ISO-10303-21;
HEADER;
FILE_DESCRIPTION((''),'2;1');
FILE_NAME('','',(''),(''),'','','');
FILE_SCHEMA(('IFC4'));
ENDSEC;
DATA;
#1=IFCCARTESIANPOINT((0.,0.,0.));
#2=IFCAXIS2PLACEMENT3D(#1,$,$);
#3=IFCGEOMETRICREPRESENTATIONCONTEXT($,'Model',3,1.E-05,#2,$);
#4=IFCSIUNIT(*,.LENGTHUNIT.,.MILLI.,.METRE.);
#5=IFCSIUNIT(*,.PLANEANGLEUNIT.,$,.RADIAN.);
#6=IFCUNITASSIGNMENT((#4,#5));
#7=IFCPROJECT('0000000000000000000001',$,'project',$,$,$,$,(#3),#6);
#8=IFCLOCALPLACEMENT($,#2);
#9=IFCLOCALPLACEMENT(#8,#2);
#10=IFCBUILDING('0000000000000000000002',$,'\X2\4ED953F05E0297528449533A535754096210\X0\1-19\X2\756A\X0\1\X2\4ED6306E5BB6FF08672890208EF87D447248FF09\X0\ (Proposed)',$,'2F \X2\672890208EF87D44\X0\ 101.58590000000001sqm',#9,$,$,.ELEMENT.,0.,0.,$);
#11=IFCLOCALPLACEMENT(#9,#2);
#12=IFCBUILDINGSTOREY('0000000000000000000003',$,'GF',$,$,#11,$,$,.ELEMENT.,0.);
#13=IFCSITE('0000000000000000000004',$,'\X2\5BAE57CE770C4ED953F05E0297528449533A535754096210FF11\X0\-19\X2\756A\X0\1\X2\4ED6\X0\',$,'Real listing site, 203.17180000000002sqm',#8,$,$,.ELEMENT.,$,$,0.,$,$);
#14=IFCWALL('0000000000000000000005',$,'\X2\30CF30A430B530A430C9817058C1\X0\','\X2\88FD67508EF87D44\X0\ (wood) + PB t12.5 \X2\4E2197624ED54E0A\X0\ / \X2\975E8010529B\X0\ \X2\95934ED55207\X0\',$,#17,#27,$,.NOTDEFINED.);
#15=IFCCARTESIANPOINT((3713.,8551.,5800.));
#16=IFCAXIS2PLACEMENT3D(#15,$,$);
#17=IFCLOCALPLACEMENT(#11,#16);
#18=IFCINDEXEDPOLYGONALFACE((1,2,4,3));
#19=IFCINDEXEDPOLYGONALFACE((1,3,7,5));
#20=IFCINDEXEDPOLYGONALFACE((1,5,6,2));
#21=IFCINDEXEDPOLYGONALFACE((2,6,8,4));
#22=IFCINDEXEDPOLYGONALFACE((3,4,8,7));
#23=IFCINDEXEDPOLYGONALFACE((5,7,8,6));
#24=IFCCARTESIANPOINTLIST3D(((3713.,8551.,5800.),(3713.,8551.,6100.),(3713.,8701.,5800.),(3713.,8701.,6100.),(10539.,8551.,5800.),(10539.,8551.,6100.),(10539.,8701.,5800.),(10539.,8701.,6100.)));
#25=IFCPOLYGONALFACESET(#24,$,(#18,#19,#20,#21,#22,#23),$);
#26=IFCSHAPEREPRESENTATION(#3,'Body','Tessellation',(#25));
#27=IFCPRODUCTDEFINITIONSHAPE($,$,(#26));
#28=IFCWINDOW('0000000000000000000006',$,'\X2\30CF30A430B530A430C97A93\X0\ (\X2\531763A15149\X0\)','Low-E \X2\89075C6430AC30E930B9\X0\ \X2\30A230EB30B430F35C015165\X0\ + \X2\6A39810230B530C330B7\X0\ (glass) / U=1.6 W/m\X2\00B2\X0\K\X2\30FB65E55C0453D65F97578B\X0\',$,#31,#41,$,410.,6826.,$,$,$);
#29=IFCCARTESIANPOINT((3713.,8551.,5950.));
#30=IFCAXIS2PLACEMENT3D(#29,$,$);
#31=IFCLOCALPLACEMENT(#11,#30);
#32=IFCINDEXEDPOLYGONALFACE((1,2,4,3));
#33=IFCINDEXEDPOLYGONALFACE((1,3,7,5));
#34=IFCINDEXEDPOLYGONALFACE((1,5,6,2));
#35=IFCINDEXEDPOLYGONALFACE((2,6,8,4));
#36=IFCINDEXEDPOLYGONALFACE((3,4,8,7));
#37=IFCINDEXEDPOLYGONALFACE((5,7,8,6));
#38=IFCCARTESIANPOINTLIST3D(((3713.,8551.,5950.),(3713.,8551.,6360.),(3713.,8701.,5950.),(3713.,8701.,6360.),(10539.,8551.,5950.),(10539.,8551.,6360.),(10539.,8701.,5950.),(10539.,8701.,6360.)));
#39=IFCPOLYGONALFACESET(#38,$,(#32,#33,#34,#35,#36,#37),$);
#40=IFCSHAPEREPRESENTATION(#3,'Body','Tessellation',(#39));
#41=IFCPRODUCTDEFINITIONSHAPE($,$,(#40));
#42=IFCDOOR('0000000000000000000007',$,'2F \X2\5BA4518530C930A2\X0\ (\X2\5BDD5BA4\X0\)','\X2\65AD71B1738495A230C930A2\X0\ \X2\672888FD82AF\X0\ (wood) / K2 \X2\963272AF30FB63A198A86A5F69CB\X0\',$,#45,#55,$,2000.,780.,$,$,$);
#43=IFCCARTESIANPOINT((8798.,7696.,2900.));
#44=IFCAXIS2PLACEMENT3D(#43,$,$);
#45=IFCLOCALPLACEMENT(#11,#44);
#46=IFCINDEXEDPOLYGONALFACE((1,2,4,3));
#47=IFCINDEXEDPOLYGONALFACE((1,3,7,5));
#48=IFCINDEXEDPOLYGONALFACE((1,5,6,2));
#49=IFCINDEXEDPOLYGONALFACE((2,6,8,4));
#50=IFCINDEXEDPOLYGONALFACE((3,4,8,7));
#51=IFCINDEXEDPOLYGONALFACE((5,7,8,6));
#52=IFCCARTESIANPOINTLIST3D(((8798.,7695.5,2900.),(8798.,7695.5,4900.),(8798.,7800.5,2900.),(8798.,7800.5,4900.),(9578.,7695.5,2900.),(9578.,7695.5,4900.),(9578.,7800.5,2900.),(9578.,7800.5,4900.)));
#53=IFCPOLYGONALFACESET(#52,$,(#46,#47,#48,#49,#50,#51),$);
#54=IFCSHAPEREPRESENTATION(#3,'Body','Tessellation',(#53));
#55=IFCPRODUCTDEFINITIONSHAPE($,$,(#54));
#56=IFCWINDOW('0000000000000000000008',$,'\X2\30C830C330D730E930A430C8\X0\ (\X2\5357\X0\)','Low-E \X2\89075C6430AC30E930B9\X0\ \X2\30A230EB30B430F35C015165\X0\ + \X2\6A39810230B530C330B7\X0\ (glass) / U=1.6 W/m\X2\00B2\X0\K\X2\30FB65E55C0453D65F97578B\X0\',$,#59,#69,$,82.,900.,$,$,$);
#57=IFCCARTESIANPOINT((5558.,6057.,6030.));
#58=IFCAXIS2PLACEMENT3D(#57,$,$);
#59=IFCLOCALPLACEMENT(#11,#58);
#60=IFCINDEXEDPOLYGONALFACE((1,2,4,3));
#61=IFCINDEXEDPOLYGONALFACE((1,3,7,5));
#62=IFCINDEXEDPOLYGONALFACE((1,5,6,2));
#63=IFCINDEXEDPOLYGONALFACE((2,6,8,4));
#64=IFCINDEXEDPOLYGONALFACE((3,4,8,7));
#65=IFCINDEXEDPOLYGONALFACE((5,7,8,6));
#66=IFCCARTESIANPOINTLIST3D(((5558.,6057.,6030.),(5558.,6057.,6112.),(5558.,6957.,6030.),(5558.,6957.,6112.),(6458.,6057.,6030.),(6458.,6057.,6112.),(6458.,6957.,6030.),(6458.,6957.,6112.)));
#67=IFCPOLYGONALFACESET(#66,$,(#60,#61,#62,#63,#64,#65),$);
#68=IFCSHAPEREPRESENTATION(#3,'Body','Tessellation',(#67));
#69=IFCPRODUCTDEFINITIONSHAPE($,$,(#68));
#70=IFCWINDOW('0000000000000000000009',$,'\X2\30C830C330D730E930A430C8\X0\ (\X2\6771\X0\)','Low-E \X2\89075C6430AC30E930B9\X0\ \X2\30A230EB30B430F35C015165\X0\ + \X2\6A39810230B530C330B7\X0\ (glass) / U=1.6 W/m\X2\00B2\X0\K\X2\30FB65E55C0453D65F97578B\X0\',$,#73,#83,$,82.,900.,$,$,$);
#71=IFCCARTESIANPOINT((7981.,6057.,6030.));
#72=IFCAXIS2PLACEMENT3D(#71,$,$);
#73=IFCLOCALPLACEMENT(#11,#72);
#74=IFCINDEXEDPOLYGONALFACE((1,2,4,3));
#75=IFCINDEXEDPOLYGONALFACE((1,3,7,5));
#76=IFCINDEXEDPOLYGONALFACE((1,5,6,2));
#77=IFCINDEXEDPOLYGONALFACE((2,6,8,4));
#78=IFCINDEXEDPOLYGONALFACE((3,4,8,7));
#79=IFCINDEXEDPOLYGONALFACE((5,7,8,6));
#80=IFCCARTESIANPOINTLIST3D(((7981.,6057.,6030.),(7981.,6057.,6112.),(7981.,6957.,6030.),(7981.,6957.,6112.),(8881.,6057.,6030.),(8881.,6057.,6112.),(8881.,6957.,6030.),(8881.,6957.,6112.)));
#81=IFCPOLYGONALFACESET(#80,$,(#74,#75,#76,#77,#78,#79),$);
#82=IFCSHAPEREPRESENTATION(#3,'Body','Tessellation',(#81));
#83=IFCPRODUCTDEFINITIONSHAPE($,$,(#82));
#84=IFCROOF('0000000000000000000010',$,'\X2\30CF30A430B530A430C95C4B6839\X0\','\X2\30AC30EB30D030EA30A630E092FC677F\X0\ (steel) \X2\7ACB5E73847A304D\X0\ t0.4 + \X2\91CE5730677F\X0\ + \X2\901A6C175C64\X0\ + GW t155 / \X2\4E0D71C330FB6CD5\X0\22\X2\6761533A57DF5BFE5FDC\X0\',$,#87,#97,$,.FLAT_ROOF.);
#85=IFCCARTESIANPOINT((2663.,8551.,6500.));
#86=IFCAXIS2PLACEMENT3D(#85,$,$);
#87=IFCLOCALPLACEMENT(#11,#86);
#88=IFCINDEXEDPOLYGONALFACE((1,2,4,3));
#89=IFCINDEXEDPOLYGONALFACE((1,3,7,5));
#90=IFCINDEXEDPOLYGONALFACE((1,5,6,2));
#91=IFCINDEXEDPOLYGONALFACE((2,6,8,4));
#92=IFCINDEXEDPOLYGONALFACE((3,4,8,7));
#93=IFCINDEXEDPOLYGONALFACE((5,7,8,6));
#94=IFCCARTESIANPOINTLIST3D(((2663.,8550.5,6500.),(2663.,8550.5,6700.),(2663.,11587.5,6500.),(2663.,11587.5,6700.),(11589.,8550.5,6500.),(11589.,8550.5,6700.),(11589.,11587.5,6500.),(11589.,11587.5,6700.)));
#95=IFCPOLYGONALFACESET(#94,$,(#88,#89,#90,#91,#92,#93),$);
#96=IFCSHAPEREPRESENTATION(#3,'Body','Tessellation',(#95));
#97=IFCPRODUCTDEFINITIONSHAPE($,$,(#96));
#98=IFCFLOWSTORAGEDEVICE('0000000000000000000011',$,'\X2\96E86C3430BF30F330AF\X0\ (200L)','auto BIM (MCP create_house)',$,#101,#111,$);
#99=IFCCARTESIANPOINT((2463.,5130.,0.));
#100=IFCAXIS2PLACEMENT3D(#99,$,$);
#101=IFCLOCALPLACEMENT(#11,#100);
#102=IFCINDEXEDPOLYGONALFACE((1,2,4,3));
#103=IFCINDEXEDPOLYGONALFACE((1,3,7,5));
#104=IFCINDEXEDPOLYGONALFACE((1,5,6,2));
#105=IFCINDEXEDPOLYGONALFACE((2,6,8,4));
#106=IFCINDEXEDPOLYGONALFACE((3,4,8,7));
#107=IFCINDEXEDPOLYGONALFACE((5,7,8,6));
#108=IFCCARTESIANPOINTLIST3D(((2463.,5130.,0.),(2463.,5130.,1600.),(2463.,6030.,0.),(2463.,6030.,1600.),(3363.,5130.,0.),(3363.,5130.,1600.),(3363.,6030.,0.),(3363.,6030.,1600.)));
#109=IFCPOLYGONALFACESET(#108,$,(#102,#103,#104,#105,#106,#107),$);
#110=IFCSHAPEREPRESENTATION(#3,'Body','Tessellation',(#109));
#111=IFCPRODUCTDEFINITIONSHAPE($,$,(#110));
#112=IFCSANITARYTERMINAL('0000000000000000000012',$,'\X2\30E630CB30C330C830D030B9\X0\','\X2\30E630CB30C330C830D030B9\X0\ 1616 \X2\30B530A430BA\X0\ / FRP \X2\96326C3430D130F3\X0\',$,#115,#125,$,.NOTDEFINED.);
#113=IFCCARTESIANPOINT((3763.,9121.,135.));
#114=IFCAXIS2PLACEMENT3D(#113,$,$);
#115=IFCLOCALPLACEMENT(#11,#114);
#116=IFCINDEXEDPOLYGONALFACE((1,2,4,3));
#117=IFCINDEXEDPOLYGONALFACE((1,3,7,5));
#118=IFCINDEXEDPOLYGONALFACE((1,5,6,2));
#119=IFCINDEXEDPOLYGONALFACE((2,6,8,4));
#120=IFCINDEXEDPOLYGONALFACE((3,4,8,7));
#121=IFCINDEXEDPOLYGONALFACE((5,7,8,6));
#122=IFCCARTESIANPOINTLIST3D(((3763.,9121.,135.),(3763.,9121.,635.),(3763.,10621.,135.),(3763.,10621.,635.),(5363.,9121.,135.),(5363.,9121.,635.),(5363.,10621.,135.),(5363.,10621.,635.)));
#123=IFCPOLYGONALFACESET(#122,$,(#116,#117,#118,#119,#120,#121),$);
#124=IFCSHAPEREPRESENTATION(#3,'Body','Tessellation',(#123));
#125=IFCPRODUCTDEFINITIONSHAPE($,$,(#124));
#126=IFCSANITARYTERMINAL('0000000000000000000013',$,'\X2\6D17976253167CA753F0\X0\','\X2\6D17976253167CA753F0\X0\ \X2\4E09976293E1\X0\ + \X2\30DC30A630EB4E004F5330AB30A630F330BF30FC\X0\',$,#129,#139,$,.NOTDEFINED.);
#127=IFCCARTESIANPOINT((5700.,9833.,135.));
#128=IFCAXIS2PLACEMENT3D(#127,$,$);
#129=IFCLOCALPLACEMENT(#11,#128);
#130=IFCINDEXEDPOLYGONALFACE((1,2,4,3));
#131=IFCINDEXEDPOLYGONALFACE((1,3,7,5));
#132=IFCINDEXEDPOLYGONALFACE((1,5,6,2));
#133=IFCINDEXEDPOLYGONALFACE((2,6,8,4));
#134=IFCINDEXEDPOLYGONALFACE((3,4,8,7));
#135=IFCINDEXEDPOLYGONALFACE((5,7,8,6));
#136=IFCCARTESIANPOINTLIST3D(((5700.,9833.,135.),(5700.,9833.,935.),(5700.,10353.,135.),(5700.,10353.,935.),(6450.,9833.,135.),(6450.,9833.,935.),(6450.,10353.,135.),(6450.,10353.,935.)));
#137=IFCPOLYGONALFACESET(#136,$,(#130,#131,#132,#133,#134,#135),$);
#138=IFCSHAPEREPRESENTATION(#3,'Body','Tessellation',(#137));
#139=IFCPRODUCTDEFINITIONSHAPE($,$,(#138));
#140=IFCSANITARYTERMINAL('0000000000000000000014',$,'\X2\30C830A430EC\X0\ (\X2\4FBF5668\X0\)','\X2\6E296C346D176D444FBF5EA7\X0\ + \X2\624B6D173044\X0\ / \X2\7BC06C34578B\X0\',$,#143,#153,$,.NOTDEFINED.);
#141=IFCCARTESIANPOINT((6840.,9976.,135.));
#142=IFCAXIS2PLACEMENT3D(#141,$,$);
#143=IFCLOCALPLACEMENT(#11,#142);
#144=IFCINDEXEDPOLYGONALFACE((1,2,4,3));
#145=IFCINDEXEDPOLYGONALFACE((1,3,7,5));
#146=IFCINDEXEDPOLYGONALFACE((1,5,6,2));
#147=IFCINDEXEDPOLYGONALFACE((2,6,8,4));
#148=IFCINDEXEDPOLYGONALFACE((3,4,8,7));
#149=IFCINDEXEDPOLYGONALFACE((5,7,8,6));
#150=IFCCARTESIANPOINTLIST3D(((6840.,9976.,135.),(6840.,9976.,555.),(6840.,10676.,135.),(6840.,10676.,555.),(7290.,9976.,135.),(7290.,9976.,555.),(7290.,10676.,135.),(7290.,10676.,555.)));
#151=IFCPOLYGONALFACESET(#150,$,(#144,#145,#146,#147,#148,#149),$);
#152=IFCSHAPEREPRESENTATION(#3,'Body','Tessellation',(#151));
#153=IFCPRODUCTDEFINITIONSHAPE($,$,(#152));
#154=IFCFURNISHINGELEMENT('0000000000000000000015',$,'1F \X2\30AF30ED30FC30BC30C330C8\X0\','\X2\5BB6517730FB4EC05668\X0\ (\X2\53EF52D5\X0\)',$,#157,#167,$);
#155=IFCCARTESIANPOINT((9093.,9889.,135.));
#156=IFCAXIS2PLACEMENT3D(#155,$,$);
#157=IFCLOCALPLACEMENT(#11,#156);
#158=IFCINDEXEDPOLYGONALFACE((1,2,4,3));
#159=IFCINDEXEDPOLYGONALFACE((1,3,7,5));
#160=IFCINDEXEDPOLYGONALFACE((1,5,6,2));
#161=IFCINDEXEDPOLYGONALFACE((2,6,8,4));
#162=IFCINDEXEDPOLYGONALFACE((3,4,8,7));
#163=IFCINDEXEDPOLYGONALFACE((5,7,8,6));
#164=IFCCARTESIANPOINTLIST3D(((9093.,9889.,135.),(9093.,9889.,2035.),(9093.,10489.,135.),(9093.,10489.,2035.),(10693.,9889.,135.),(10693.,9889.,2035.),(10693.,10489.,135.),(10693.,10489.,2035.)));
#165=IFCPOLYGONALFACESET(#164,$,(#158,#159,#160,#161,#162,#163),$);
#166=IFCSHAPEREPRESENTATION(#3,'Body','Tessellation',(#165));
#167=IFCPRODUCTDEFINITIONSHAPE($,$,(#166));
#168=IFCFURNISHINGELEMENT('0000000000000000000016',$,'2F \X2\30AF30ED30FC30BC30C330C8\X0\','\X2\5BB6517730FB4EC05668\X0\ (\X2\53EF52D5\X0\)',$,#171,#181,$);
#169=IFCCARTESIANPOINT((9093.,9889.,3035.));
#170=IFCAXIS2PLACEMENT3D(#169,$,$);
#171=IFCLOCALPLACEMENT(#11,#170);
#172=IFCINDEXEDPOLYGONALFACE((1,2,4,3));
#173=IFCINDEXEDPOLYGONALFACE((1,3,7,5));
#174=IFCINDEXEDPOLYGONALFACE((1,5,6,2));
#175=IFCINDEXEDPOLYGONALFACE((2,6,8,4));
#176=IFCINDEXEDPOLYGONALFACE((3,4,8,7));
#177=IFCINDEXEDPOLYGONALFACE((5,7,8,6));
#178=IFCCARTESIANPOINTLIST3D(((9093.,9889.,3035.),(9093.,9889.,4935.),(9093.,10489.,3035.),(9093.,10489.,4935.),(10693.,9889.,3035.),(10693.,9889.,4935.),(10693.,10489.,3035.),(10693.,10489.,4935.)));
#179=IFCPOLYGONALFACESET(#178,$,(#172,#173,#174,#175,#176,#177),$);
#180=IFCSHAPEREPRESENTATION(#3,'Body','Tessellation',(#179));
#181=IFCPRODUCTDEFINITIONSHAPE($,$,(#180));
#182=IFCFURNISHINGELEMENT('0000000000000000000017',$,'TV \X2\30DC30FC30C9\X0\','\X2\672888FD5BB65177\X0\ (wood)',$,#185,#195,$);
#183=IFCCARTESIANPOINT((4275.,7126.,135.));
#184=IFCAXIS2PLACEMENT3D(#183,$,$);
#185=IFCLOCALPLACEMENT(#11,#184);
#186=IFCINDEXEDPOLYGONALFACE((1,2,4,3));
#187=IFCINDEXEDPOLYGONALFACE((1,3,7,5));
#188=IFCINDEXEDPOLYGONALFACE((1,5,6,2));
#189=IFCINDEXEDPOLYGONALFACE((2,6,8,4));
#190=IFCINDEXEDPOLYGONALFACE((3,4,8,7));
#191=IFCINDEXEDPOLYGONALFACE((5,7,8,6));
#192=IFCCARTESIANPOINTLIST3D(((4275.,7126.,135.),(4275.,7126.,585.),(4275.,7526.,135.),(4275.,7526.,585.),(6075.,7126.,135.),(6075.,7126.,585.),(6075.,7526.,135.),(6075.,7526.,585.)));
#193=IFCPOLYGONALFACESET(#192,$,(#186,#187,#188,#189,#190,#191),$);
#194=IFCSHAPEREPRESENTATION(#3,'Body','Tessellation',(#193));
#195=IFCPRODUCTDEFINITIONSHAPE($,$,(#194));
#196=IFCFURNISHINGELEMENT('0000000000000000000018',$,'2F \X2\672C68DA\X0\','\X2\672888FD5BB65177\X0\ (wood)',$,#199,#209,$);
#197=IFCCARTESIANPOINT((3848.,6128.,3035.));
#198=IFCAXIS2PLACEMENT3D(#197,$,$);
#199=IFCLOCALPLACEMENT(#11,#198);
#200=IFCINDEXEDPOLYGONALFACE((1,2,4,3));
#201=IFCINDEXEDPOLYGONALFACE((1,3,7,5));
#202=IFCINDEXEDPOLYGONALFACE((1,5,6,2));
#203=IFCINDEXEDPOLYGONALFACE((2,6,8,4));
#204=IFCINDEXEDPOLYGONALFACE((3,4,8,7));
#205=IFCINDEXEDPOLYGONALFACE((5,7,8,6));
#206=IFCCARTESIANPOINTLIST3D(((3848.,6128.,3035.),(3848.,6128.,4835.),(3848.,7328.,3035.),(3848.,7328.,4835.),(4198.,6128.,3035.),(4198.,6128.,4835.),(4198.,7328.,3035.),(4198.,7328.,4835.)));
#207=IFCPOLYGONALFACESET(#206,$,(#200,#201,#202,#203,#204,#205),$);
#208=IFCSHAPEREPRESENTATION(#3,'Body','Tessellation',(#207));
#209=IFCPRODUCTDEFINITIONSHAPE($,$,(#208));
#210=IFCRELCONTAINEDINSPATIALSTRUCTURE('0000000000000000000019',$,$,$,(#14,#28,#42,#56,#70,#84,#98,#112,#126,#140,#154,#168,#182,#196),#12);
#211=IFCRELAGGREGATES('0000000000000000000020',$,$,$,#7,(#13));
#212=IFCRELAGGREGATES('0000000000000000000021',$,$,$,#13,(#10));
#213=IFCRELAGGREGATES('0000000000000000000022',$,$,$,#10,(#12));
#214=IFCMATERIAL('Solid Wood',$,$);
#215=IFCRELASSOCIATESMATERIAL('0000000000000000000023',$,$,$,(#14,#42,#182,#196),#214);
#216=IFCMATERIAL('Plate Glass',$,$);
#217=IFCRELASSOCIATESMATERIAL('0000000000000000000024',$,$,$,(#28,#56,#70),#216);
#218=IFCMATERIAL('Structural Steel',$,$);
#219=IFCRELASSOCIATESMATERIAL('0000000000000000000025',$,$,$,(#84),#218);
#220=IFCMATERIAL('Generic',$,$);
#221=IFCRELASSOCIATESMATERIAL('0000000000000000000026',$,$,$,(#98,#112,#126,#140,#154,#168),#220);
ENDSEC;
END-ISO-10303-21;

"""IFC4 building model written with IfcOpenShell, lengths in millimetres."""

from ifc_helpers import new_model, si_unit, frame, frame_2d, origin, place, context, project, spatial, rectangle, extrude, material, element, fill, save


model = new_model("IFC4")

# Units and contexts
model_context = context("Model", 3, precision=1e-05, world=origin())
ifc_project = project(units=[si_unit("LENGTHUNIT", "METRE", prefix="MILLI"), si_unit("PLANEANGLEUNIT", "RADIAN")], contexts=[model_context])

# Site, building, storey
site_placement = place(None, origin())
site = spatial("IfcSite", under=ifc_project, at=site_placement, Name="宮城県仙台市青葉区南吉成１-19番1他", ObjectType="Real listing site, 203.17180000000002sqm", CompositionType="ELEMENT", RefElevation=0.0)
building_placement = place(site_placement, origin())
building = spatial("IfcBuilding", under=site, at=building_placement, Name="仙台市青葉区南吉成1-19番1他の家（木造軸組版） (Proposed)", ObjectType="2F 木造軸組 101.58590000000001sqm", CompositionType="ELEMENT", ElevationOfRefHeight=0.0, ElevationOfTerrain=0.0)
storey_placement = place(building_placement, origin())
storey = spatial("IfcBuildingStorey", under=building, at=storey_placement, Name="GF", CompositionType="ELEMENT", Elevation=0.0)

# Shared definitions
ifc_material_1 = material(Name="Solid Wood")
ifc_material_2 = material(Name="Plate Glass")

# Wall, opening, window
wall_1_placement = place(storey_placement, frame((3713.0, 8551.0, 5800.0)))
wall_1 = element("IfcWall", 1, at=wall_1_placement, inside=storey, material=ifc_material_1, Name="ハイサイド腰壁", Description="製材軸組 (wood) + PB t12.5 両面仕上 / 非耐力 間仕切", PredefinedType="NOTDEFINED", context=model_context, shape_type="SweptSolid", body=[
    extrude(rectangle(XDim=6826.0, YDim=150.0, at=frame_2d((3413.0, 75.0))), frame((3713.0, 8551.0, 5800.0)), (0.0, 0.0, 1.0), 700.0),
])
opening_1_placement = place(storey_placement, frame((3713.0, 8551.0, 5950.0)))
opening_1 = element("IfcOpeningElement", 2, at=opening_1_placement, cuts=wall_1, PredefinedType="NOTDEFINED", context=model_context, shape_type="SweptSolid", body=[
    extrude(rectangle(XDim=6826.0, YDim=150.0, at=frame_2d((3413.0, 75.0))), frame((3713.0, 8551.0, 5950.0)), (0.0, 0.0, 1.0), 410.0),
])
window_1_placement = place(storey_placement, frame((3713.0, 8551.0, 5950.0)))
window_1 = element("IfcWindow", 3, at=window_1_placement, inside=storey, material=ifc_material_2, Name="ハイサイド窓 (北採光)", Description="Low-E 複層ガラス アルゴン封入 + 樹脂サッシ (glass) / U=1.6 W/m²K・日射取得型", OverallHeight=410.0, OverallWidth=6826.0, context=model_context, shape_type="SweptSolid", body=[
    extrude(rectangle(XDim=6826.0, YDim=150.0, at=frame_2d((3413.0, 75.0))), frame((3713.0, 8551.0, 5950.0)), (0.0, 0.0, 1.0), 410.0),
])
fill(opening_1, window_1)

# Door
door_1_placement = place(storey_placement, frame((8798.0, 7696.0, 2900.0)))
element("IfcDoor", 4, at=door_1_placement, inside=storey, material=ifc_material_1, Name="2F 室内ドア (寝室)", Description="断熱玄関ドア 木製芯 (wood) / K2 防犯・採風機構", OverallHeight=2000.0, OverallWidth=780.0, context=model_context, shape_type="SweptSolid", body=[
    extrude(rectangle(XDim=780.0, YDim=105.0, at=frame_2d((390.0, 52.0))), frame((8798.0, 7696.0, 2900.0)), (0.0, 0.0, 1.0), 2000.0),
])

# Windows
window_2_placement = place(storey_placement, frame((5558.0, 6057.0, 6030.0)))
element("IfcWindow", 5, at=window_2_placement, inside=storey, material=ifc_material_2, Name="トップライト (南)", Description="Low-E 複層ガラス アルゴン封入 + 樹脂サッシ (glass) / U=1.6 W/m²K・日射取得型", OverallHeight=82.0, OverallWidth=900.0, context=model_context, shape_type="SweptSolid", body=[
    extrude(rectangle(XDim=900.0, YDim=900.0, at=frame_2d((450.0, 450.0))), frame((5558.0, 6057.0, 6030.0)), (0.0, 0.0, 1.0), 82.0),
])
window_3_placement = place(storey_placement, frame((7981.0, 6057.0, 6030.0)))
element("IfcWindow", 6, at=window_3_placement, inside=storey, material=ifc_material_2, Name="トップライト (東)", Description="Low-E 複層ガラス アルゴン封入 + 樹脂サッシ (glass) / U=1.6 W/m²K・日射取得型", OverallHeight=82.0, OverallWidth=900.0, context=model_context, shape_type="SweptSolid", body=[
    extrude(rectangle(XDim=900.0, YDim=900.0, at=frame_2d((450.0, 450.0))), frame((7981.0, 6057.0, 6030.0)), (0.0, 0.0, 1.0), 82.0),
])

# Roof
ifc_material_3 = material(Name="Structural Steel")
roof_placement = place(storey_placement, frame((2663.0, 8551.0, 6500.0)))
element("IfcRoof", 7, at=roof_placement, inside=storey, material=ifc_material_3, Name="ハイサイド屋根", Description="ガルバリウム鋼板 (steel) 立平葺き t0.4 + 野地板 + 通気層 + GW t155 / 不燃・法22条区域対応", PredefinedType="FLAT_ROOF", context=model_context, shape_type="SweptSolid", body=[
    extrude(rectangle(XDim=8926.0, YDim=3037.0, at=frame_2d((4463.0, 1518.0))), frame((2663.0, 8551.0, 6500.0)), (0.0, 0.0, 1.0), 200.0),
])

# Flow storage device
ifc_material_4 = material(Name="Generic")
flow_storage_device_placement = place(storey_placement, frame((2463.0, 5130.0, 0.0)))
element("IfcFlowStorageDevice", 8, at=flow_storage_device_placement, inside=storey, material=ifc_material_4, Name="雨水タンク (200L)", Description="auto BIM (MCP create_house)", context=model_context, shape_type="SweptSolid", body=[
    extrude(rectangle(XDim=900.0, YDim=900.0, at=frame_2d((450.0, 450.0))), frame((2463.0, 5130.0, 0.0)), (0.0, 0.0, 1.0), 1600.0),
])

# Sanitary terminals
sanitary_terminal_1_placement = place(storey_placement, frame((3763.0, 9121.0, 135.0)))
element("IfcSanitaryTerminal", 9, at=sanitary_terminal_1_placement, inside=storey, material=ifc_material_4, Name="ユニットバス", Description="ユニットバス 1616 サイズ / FRP 防水パン", PredefinedType="NOTDEFINED", context=model_context, shape_type="SweptSolid", body=[
    extrude(rectangle(XDim=1600.0, YDim=1500.0, at=frame_2d((800.0, 750.0))), frame((3763.0, 9121.0, 135.0)), (0.0, 0.0, 1.0), 500.0),
])
sanitary_terminal_2_placement = place(storey_placement, frame((5700.0, 9833.0, 135.0)))
element("IfcSanitaryTerminal", 10, at=sanitary_terminal_2_placement, inside=storey, material=ifc_material_4, Name="洗面化粧台", Description="洗面化粧台 三面鏡 + ボウル一体カウンター", PredefinedType="NOTDEFINED", context=model_context, shape_type="SweptSolid", body=[
    extrude(rectangle(XDim=750.0, YDim=520.0, at=frame_2d((375.0, 260.0))), frame((5700.0, 9833.0, 135.0)), (0.0, 0.0, 1.0), 800.0),
])
sanitary_terminal_3_placement = place(storey_placement, frame((6840.0, 9976.0, 135.0)))
element("IfcSanitaryTerminal", 11, at=sanitary_terminal_3_placement, inside=storey, material=ifc_material_4, Name="トイレ (便器)", Description="温水洗浄便座 + 手洗い / 節水型", PredefinedType="NOTDEFINED", context=model_context, shape_type="SweptSolid", body=[
    extrude(rectangle(XDim=450.0, YDim=700.0, at=frame_2d((225.0, 350.0))), frame((6840.0, 9976.0, 135.0)), (0.0, 0.0, 1.0), 420.0),
])

# Furnishing elements
furnishing_1_placement = place(storey_placement, frame((9093.0, 9889.0, 135.0)))
element("IfcFurnishingElement", 12, at=furnishing_1_placement, inside=storey, material=ifc_material_4, Name="1F クローゼット", Description="家具・什器 (可動)", context=model_context, shape_type="SweptSolid", body=[
    extrude(rectangle(XDim=1600.0, YDim=600.0, at=frame_2d((800.0, 300.0))), frame((9093.0, 9889.0, 135.0)), (0.0, 0.0, 1.0), 1900.0),
])
furnishing_2_placement = place(storey_placement, frame((9093.0, 9889.0, 3035.0)))
element("IfcFurnishingElement", 13, at=furnishing_2_placement, inside=storey, material=ifc_material_4, Name="2F クローゼット", Description="家具・什器 (可動)", context=model_context, shape_type="SweptSolid", body=[
    extrude(rectangle(XDim=1600.0, YDim=600.0, at=frame_2d((800.0, 300.0))), frame((9093.0, 9889.0, 3035.0)), (0.0, 0.0, 1.0), 1900.0),
])
furnishing_3_placement = place(storey_placement, frame((4275.0, 7126.0, 135.0)))
element("IfcFurnishingElement", 14, at=furnishing_3_placement, inside=storey, material=ifc_material_1, Name="TV ボード", Description="木製家具 (wood)", context=model_context, shape_type="SweptSolid", body=[
    extrude(rectangle(XDim=1800.0, YDim=400.0, at=frame_2d((900.0, 200.0))), frame((4275.0, 7126.0, 135.0)), (0.0, 0.0, 1.0), 450.0),
])
furnishing_4_placement = place(storey_placement, frame((3848.0, 6128.0, 3035.0)))
element("IfcFurnishingElement", 15, at=furnishing_4_placement, inside=storey, material=ifc_material_1, Name="2F 本棚", Description="木製家具 (wood)", context=model_context, shape_type="SweptSolid", body=[
    extrude(rectangle(XDim=350.0, YDim=1200.0, at=frame_2d((175.0, 600.0))), frame((3848.0, 6128.0, 3035.0)), (0.0, 0.0, 1.0), 1800.0),
])

save(model, "model.ifc")
